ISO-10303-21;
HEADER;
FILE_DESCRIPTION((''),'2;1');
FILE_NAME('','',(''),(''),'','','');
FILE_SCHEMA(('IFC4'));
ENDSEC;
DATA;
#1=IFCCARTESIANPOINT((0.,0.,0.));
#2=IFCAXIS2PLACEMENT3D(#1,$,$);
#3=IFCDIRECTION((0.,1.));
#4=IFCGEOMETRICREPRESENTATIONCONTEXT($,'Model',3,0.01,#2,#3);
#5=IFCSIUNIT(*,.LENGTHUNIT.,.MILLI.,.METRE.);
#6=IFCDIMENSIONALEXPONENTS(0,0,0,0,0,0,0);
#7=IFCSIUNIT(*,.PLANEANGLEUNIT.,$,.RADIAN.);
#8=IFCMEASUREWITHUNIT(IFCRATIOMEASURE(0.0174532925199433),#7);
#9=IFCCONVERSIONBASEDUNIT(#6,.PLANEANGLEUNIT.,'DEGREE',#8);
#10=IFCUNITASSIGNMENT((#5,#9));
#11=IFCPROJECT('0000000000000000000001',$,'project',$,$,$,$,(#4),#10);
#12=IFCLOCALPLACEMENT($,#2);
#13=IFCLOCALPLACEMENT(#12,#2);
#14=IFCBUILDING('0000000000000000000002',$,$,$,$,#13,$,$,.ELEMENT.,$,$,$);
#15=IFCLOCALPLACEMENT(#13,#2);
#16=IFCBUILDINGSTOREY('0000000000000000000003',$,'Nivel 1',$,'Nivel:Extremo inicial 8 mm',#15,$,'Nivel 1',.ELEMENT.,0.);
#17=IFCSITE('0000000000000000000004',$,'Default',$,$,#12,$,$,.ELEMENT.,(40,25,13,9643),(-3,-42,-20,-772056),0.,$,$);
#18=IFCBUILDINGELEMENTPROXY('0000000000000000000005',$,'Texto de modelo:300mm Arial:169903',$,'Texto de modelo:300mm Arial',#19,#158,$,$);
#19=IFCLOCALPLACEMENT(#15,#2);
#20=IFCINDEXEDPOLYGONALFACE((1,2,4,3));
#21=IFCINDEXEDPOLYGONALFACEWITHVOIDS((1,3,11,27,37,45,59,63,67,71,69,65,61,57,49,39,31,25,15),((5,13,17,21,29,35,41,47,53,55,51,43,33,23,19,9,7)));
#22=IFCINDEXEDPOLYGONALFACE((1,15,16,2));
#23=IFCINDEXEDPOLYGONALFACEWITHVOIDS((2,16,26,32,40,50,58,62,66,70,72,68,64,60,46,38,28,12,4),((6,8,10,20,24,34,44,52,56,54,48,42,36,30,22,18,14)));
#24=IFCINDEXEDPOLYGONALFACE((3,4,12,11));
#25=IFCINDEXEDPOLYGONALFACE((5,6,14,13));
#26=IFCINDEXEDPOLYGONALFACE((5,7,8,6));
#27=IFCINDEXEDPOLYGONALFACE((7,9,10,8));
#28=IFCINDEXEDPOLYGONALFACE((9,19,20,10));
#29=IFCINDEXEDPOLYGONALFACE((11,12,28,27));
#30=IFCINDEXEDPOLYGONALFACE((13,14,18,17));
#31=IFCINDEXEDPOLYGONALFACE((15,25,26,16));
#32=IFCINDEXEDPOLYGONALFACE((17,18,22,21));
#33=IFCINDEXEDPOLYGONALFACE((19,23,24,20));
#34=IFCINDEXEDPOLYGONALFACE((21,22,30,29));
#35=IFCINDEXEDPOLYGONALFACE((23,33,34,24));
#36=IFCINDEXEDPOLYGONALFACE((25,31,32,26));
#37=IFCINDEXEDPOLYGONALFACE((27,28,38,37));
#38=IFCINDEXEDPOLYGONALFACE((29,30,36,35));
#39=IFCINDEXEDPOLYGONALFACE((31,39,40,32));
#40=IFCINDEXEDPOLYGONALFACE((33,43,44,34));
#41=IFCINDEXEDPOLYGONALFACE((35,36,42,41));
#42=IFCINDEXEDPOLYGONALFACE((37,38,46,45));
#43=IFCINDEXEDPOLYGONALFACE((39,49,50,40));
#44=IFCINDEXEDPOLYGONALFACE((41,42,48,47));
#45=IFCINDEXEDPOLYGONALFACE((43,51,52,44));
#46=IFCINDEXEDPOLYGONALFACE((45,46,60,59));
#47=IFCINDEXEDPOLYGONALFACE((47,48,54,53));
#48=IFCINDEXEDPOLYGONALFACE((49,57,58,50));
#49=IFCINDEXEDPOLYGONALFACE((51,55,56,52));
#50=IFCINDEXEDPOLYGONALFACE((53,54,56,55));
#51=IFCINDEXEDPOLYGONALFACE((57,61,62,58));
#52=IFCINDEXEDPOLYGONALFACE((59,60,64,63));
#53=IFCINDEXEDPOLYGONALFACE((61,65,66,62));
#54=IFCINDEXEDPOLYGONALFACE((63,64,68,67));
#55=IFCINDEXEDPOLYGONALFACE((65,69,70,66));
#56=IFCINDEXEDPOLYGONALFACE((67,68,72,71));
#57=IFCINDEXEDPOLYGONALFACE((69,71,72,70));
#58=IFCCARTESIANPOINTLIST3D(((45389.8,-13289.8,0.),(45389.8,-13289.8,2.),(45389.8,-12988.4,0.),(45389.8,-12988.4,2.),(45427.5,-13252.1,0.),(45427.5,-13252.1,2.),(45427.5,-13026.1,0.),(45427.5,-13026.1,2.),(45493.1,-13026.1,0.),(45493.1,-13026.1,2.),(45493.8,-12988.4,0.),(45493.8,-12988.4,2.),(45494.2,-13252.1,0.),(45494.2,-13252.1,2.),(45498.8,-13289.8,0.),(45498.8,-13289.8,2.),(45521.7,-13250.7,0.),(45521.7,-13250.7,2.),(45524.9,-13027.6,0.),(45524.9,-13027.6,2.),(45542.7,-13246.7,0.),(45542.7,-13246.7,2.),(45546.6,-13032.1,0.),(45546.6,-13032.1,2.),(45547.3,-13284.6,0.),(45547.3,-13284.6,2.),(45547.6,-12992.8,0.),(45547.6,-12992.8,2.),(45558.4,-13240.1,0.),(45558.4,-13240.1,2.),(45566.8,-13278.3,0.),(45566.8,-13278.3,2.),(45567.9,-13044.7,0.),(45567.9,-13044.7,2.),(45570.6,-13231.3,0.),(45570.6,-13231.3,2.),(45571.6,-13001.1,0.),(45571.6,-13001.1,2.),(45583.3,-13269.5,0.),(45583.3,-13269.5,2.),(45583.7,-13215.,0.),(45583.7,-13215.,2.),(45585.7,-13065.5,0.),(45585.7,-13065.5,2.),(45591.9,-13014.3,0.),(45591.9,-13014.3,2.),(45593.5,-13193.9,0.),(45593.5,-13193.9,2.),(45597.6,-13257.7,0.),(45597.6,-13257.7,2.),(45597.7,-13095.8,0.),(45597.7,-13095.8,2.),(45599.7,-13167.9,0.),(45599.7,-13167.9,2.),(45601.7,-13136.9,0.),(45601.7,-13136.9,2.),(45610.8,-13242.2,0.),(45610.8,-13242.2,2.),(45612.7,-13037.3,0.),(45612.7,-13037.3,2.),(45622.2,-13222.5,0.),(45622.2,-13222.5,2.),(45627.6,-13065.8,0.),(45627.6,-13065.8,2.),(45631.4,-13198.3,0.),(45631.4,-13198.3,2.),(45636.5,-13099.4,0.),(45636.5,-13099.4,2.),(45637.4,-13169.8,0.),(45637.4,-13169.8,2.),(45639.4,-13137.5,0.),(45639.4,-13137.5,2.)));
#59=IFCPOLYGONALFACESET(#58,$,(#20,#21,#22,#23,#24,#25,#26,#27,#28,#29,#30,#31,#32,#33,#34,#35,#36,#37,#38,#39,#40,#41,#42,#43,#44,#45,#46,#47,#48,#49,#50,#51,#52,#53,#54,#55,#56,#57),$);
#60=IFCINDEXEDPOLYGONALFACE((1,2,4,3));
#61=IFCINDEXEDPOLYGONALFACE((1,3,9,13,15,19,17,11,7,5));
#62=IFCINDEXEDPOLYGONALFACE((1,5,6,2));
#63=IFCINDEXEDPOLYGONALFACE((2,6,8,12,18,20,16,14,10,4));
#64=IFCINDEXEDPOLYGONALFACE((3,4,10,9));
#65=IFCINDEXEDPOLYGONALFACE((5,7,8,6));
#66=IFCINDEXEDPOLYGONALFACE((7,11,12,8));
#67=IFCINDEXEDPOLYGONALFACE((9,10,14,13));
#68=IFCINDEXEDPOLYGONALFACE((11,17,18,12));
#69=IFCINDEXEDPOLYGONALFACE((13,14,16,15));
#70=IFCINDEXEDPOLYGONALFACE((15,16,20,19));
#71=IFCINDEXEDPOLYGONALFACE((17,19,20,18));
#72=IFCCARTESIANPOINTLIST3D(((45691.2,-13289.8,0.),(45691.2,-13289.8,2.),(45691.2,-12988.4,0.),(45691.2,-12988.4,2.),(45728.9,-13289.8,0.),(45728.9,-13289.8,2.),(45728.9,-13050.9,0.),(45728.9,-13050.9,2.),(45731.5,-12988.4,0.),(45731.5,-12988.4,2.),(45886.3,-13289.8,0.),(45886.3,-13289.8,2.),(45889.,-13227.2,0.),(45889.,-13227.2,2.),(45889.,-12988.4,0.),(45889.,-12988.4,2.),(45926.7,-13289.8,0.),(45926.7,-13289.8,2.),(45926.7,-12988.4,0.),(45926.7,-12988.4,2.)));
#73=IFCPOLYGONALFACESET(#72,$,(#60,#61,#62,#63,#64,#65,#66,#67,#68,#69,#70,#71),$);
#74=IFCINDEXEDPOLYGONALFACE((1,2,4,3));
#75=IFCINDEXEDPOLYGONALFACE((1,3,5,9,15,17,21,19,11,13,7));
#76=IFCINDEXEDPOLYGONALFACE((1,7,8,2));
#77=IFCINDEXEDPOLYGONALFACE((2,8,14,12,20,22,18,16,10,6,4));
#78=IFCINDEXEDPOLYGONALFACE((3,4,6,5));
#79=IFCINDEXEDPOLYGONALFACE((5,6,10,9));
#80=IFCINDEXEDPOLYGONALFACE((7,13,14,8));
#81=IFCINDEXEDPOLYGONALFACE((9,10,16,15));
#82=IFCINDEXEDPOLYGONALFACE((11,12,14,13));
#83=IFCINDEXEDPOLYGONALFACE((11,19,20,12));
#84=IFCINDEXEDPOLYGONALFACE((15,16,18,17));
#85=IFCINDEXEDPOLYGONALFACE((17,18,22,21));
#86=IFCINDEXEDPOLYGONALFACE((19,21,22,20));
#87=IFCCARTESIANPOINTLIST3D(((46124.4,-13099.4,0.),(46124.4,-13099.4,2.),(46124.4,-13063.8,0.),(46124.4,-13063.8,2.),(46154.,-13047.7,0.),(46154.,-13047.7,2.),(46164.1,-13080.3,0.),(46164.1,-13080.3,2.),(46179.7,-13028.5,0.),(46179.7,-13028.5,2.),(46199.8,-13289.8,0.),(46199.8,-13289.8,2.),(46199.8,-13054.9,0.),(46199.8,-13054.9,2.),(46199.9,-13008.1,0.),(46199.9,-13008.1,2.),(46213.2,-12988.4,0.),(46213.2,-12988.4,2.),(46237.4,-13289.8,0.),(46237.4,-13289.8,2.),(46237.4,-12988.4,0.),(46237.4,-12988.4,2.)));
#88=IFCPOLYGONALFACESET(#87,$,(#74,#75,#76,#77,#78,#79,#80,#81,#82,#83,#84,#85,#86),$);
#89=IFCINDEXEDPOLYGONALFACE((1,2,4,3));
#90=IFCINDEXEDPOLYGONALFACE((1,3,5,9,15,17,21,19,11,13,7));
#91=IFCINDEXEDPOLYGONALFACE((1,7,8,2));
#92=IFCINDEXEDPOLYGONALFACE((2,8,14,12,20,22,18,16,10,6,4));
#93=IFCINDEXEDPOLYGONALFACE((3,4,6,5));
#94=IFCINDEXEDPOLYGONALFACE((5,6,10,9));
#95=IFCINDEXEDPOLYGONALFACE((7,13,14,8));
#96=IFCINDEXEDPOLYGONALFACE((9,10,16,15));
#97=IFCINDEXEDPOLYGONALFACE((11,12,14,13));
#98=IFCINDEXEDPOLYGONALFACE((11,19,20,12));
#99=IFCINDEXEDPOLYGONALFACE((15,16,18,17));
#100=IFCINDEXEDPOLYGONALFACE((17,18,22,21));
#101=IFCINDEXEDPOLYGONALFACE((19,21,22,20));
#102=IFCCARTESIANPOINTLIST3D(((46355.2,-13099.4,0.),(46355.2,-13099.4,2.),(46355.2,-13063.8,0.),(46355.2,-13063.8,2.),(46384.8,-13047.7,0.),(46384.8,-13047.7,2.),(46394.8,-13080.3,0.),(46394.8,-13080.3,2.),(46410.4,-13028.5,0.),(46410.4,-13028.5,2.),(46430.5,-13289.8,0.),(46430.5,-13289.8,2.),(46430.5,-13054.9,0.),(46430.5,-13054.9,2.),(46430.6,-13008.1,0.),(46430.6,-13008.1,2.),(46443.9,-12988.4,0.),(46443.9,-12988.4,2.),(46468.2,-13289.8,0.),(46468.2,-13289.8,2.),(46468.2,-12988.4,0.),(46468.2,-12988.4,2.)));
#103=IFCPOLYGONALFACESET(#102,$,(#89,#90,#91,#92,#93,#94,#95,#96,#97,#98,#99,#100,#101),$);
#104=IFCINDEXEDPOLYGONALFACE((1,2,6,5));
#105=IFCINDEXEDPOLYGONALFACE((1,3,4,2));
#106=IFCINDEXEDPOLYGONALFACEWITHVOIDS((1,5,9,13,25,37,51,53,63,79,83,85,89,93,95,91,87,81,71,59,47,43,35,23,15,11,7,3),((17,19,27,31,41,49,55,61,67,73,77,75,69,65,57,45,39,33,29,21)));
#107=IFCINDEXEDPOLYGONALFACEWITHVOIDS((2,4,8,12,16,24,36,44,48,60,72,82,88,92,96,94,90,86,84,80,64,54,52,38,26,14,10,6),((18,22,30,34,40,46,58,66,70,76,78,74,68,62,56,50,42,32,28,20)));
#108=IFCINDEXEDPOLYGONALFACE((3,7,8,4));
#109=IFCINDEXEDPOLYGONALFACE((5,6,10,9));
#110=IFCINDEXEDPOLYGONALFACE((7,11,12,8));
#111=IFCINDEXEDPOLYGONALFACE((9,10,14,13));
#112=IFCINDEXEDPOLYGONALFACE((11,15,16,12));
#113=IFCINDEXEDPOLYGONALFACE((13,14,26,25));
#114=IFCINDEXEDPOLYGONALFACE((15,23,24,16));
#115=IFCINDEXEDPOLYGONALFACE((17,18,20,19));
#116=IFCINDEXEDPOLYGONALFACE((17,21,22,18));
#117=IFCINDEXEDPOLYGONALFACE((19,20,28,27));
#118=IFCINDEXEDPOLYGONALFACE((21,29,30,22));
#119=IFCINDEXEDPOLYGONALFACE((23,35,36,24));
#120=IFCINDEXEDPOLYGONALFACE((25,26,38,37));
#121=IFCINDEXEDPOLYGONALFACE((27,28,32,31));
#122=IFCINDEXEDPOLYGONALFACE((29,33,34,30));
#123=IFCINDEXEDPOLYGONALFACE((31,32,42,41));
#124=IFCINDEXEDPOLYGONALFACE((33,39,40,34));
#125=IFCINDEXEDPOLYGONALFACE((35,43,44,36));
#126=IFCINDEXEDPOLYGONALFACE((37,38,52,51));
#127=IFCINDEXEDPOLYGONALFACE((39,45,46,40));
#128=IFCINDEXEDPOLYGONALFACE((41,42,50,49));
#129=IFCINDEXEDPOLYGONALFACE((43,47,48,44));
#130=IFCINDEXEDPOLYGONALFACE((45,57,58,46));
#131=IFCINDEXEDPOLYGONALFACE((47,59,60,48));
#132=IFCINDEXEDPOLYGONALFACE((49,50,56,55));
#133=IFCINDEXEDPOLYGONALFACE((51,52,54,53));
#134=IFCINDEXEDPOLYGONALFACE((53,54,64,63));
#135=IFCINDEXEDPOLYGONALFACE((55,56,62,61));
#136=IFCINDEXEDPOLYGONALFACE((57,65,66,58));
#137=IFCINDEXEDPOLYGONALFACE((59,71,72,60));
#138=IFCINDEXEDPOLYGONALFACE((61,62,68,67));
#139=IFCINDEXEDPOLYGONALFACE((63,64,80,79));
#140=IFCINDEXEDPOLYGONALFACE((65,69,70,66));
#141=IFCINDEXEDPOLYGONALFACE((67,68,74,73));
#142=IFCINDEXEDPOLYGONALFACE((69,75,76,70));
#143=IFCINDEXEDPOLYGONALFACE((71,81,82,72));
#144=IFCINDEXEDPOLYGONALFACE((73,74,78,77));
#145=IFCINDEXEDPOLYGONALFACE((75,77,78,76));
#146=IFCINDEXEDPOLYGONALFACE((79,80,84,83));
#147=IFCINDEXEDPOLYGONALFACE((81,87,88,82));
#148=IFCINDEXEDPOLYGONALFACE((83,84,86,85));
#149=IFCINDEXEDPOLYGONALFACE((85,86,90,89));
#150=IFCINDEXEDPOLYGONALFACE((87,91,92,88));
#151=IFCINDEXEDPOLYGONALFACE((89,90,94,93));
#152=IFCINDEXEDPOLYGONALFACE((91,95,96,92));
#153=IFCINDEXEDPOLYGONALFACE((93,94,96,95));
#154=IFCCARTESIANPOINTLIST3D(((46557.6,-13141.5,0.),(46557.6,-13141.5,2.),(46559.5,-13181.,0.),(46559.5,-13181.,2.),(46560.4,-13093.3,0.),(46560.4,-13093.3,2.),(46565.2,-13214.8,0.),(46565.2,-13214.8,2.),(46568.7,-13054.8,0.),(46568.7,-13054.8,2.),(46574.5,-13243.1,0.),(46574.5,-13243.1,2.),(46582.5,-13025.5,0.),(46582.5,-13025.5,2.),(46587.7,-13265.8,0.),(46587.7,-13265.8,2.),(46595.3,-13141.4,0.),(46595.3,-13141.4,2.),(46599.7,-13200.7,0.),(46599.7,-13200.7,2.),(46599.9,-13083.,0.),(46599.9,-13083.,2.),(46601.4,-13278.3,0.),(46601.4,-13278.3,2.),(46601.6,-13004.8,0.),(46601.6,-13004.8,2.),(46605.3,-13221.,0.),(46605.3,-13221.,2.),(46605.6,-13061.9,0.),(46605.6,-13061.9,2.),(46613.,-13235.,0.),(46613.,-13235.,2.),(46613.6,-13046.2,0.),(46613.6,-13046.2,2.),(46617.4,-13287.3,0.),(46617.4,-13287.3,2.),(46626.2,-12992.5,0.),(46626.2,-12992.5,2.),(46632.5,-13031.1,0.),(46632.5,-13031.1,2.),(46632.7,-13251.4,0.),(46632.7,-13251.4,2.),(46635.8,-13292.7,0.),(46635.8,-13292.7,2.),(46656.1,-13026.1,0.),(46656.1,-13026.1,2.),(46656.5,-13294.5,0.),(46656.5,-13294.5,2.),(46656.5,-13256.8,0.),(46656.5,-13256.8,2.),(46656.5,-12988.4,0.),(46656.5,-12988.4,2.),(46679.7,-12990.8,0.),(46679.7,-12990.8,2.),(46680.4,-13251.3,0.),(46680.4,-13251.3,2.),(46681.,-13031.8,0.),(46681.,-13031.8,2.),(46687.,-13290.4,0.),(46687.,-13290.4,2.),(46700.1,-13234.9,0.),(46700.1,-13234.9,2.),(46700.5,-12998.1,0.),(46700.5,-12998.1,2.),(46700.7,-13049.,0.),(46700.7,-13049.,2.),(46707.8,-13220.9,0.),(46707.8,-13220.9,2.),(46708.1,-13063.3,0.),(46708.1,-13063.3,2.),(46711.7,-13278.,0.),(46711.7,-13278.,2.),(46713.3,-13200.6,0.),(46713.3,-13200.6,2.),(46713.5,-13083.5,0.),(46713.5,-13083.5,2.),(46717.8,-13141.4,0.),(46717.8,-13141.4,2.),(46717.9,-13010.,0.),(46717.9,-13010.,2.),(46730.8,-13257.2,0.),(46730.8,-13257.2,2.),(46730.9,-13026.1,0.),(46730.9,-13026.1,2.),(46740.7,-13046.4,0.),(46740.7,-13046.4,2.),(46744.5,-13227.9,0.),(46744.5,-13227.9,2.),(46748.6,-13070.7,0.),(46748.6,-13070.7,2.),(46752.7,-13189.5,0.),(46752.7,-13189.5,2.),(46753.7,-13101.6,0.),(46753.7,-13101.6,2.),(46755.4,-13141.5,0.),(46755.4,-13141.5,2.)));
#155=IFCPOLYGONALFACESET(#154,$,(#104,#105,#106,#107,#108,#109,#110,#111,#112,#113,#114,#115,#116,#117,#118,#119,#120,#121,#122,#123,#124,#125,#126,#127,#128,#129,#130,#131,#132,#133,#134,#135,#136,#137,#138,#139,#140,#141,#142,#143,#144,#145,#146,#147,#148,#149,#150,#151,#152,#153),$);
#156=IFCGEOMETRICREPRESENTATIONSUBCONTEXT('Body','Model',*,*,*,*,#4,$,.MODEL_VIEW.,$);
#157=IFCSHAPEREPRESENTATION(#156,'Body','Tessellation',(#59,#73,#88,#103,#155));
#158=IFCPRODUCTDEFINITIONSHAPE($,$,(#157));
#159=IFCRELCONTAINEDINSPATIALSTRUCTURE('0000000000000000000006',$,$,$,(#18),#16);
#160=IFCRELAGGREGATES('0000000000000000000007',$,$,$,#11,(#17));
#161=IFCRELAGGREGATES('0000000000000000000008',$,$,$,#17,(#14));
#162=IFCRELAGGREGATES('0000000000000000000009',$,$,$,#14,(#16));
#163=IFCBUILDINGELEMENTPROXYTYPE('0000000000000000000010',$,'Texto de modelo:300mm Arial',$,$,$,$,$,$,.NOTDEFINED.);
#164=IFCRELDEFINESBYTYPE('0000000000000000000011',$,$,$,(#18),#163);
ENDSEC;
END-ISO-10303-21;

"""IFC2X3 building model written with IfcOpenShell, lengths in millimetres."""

from ifc_helpers import new_model, entity, si_unit, converted_unit, direction, frame, origin, place, context, subcontext, project, spatial, polyline, outline, extrude, type_object, element, save


model = new_model("IFC2X3")

# Units and contexts
model_context = context("Model", 3, precision=0.01, world=origin(), true_north=direction((0.0, 1.0)))
body_context = subcontext(model_context, "Body", "Model", "MODEL_VIEW")
ifc_project = project(units=[si_unit("LENGTHUNIT", "METRE", prefix="MILLI"), converted_unit("PLANEANGLEUNIT", "DEGREE", entity("IfcRatioMeasure", 0.0174532925199433), si_unit("PLANEANGLEUNIT", "RADIAN"), dimensions=[0, 0, 0, 0, 0, 0, 0])], contexts=[model_context])

# Site, building, storey
site_placement = place(None, origin())
site = spatial("IfcSite", under=ifc_project, at=site_placement, Name="Default", CompositionType="ELEMENT", RefLatitude=(40, 25, 13, 9643), RefLongitude=(-3, -42, -20, -772056), RefElevation=0.0)
building_placement = place(site_placement, origin())
building = spatial("IfcBuilding", under=site, at=building_placement, CompositionType="ELEMENT")
storey_placement = place(building_placement, origin())
storey = spatial("IfcBuildingStorey", under=building, at=storey_placement, Name="Nivel 1", ObjectType="Nivel:Extremo inicial 8 mm", LongName="Nivel 1", CompositionType="ELEMENT", Elevation=0.0)

# Building element proxy
building_element_proxy_type_1 = type_object("IfcBuildingElementProxyType", Name="Texto de modelo:300mm Arial", PredefinedType="NOTDEFINED")
proxy_1_placement = place(storey_placement, frame((45389.8, -13294.5, 0.0)))
element("IfcBuildingElementProxy", 1, at=proxy_1_placement, inside=storey, type_object=building_element_proxy_type_1, Name="Texto de modelo:300mm Arial:169903", ObjectType="Texto de modelo:300mm Arial", context=body_context, shape_type="SweptSolid", body=[
    extrude(outline(polyline([(-178.4, -141.0), (-69.4, -141.0), (-21.0, -135.8), (-1.4, -129.5), (15.0, -120.7), (29.4, -108.9), (42.6, -93.4), (54.0, -73.7), (63.2, -49.5), (69.2, -21.0), (71.2, 11.3), (68.2, 49.4), (59.3, 83.0), (44.5, 111.5), (23.7, 134.5), (3.4, 147.7), (-20.6, 156.1), (-74.4, 160.4), (-178.4, 160.4), (-178.4, -141.0)]), holes=[polyline([(-140.7, -103.3), (-140.7, 122.7), (-75.1, 122.7), (-43.3, 121.2), (-21.7, 116.7), (-0.4, 104.1), (17.4, 83.3), (29.5, 53.0), (33.5, 11.9), (31.5, -19.1), (25.3, -45.1), (15.5, -66.2), (2.4, -82.5), (-9.8, -91.3), (-25.6, -97.9), (-46.5, -101.9), (-74.1, -103.3), (-140.7, -103.3)])]), frame((178.4, 145.7, 0.0)), (0.0, 0.0, 1.0), 2.0),
    extrude(outline(polyline([(-117.7, -150.7), (-80.1, -150.7), (-80.1, 88.1), (77.4, -150.7), (117.7, -150.7), (117.7, 150.7), (80.1, 150.7), (80.1, -88.1), (-77.4, 150.7), (-117.7, 150.7), (-117.7, -150.7)])), frame((419.1, 155.4, 0.0)), (0.0, 0.0, 1.0), 2.0),
    extrude(outline(polyline([(-204.4, -52.5), (97.0, -52.5), (97.0, -28.2), (77.2, -14.9), (56.9, 5.3), (37.7, 30.9), (21.6, 60.5), (-14.0, 60.5), (5.0, 20.8), (30.4, -14.9), (-204.4, -14.9), (-204.4, -52.5)])), frame((795.1, 209.1, 0.0), z_axis=(0.0, 0.0, 1.0), x_axis=(0.0, 1.0, 0.0)), (0.0, 0.0, 1.0), 2.0),
    extrude(outline(polyline([(-204.4, -52.5), (97.0, -52.5), (97.0, -28.2), (77.2, -14.9), (56.9, 5.3), (37.7, 30.9), (21.6, 60.5), (-14.0, 60.5), (5.0, 20.8), (30.4, -14.9), (-204.4, -14.9), (-204.4, -52.5)])), frame((1025.8, 209.1, 0.0), z_axis=(0.0, 0.0, 1.0), x_axis=(0.0, 1.0, 0.0)), (0.0, 0.0, 1.0), 2.0),
    extrude(outline(polyline([(-5.6, -99.5), (33.9, -99.5), (68.0, -95.5), (96.7, -87.5), (120.0, -75.5), (133.2, -62.4), (142.9, -46.8), (149.1, -28.7), (151.9, -8.0), (149.2, 22.6), (138.0, 47.8), (118.2, 67.9), (89.5, 82.9), (51.6, 93.0), (3.8, 98.0), (-36.2, 98.2), (-67.3, 94.5), (-91.9, 87.9), (-112.6, 79.0), (-129.4, 66.8), (-142.0, 50.0), (-150.3, 29.6), (-153.8, 6.5), (-151.2, -23.9), (-140.1, -49.1), (-120.3, -69.2), (-91.7, -84.4), (-53.6, -94.5), (-5.6, -99.5)]), holes=[polyline([(-3.9, -61.9), (-62.1, -54.6), (-82.9, -47.9), (-98.1, -39.2), (-112.3, -19.5), (-116.2, 4.3), (-109.3, 28.9), (-91.2, 47.7), (-76.5, 54.5), (-56.1, 58.9), (1.9, 60.4), (60.8, 53.2), (80.8, 46.7), (94.5, 38.3), (109.9, 17.8), (114.3, -6.3), (107.7, -29.8), (90.4, -48.7), (76.0, -55.8), (55.5, -60.3), (-3.9, -61.9)])]), frame((1267.5, 152.1, 0.0), z_axis=(0.0, 0.0, 1.0), x_axis=(0.047515, -0.998871, 0.0)), (0.0, 0.0, 1.0), 2.0),
])

save(model, "model.ifc")
